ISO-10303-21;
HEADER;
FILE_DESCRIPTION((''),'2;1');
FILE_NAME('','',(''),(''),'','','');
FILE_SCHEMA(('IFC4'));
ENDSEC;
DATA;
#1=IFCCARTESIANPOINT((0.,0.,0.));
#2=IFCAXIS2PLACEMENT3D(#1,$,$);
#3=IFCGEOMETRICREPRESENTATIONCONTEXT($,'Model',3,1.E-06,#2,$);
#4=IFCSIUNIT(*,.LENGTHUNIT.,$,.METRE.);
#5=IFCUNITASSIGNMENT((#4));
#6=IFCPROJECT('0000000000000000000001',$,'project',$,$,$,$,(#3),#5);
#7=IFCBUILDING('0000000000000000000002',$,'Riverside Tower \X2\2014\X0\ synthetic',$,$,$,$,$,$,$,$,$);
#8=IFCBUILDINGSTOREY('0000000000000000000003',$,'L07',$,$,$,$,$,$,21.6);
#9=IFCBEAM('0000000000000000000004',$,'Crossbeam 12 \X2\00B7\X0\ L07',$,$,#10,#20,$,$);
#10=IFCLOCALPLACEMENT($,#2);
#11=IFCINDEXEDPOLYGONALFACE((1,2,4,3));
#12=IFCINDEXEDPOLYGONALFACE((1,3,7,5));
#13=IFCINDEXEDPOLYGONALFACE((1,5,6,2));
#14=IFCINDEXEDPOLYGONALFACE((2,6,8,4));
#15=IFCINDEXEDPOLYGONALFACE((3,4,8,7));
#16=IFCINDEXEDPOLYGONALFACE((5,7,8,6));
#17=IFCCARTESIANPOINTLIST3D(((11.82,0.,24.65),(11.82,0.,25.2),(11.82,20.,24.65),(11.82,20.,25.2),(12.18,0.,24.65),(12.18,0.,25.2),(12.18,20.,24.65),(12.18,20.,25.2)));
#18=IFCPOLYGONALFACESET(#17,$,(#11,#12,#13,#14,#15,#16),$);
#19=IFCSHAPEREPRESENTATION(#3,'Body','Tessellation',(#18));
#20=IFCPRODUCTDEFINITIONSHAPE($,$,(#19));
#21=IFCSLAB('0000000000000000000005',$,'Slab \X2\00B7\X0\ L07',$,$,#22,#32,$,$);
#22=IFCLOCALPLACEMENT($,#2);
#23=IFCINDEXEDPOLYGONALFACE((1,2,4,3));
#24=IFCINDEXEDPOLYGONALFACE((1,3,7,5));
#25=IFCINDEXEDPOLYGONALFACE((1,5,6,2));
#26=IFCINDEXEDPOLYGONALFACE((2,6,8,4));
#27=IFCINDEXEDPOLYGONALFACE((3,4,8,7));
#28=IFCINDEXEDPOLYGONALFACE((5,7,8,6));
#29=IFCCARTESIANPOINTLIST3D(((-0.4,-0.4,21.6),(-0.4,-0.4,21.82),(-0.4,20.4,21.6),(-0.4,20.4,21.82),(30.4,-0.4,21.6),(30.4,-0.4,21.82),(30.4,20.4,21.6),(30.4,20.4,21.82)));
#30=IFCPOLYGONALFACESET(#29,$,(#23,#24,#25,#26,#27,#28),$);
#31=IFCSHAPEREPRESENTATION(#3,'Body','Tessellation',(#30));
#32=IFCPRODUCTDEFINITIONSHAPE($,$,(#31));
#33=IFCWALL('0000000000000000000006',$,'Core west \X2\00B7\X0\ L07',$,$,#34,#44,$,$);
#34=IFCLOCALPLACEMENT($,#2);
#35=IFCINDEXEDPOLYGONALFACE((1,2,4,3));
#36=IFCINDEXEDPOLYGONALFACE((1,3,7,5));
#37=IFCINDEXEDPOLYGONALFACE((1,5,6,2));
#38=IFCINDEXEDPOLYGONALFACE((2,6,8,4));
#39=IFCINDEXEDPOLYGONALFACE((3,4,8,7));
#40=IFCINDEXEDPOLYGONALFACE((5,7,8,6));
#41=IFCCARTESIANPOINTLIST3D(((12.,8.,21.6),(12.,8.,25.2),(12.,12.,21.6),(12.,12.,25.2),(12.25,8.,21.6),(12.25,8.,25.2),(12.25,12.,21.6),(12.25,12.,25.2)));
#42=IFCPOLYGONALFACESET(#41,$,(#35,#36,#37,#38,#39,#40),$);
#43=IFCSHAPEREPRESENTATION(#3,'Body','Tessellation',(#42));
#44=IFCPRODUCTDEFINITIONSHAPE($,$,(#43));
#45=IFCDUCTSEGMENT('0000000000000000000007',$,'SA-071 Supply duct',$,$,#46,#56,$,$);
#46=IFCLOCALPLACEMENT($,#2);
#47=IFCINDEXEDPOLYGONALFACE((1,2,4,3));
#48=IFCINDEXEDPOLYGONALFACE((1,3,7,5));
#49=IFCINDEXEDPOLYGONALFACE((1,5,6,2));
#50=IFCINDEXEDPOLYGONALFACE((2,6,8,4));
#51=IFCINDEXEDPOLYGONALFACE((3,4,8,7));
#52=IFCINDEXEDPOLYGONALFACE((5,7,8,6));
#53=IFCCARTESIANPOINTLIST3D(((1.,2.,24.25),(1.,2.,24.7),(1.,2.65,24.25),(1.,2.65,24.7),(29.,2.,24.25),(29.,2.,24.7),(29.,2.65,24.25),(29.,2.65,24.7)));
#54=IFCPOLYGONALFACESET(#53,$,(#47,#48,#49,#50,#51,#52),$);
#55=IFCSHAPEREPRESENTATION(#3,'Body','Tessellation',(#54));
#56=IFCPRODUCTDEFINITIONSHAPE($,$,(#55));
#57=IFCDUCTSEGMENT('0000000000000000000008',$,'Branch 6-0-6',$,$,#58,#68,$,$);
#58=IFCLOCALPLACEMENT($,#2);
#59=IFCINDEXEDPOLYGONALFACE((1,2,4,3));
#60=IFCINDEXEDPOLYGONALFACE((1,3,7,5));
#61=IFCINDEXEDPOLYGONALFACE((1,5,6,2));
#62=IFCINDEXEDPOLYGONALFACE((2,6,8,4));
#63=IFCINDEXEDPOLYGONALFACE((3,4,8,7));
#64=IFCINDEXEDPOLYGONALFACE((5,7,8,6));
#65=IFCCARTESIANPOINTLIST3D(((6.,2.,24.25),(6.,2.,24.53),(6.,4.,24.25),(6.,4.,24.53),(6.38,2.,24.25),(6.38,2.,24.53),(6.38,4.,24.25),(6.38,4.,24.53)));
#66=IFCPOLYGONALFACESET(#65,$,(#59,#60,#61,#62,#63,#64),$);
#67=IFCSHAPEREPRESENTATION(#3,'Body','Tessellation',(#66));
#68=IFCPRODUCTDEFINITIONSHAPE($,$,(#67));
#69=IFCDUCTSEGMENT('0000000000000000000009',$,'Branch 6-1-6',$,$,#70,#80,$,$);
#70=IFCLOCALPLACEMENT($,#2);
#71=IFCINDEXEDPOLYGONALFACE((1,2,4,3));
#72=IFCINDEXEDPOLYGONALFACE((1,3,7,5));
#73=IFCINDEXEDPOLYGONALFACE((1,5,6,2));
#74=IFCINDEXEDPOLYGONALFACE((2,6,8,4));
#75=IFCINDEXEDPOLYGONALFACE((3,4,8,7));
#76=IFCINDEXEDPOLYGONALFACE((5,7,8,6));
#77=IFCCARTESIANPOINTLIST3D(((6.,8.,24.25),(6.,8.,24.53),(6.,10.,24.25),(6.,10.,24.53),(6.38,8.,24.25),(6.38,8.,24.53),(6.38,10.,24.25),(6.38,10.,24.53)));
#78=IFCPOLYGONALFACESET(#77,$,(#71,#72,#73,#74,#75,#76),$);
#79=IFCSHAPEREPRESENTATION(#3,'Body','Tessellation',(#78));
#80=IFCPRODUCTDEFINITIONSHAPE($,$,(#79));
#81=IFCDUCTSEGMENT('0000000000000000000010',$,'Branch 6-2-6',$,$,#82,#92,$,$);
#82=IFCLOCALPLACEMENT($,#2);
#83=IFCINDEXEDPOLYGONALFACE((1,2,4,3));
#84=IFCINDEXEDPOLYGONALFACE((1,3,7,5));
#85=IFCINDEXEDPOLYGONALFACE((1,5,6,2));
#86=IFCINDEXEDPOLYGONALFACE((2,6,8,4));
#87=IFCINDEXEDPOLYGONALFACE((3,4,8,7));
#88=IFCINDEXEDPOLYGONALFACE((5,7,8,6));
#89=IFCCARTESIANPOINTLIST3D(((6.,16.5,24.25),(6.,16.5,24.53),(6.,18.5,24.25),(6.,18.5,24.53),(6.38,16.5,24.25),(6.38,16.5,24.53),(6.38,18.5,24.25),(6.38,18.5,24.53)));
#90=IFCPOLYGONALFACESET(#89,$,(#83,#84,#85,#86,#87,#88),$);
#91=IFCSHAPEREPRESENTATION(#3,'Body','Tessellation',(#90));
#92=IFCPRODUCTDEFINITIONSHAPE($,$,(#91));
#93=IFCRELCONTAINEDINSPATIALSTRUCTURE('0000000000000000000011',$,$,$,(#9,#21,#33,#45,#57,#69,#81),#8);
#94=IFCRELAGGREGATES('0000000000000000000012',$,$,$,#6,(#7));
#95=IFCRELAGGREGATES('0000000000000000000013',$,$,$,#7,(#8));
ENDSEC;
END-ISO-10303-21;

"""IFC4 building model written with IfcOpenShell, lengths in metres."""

from ifc_helpers import new_model, si_unit, frame, origin, place, context, project, spatial, rectangle, extrude, element, save


model = new_model("IFC4")

# Units and contexts
model_context = context("Model", 3, precision=1e-06, world=origin())
ifc_project = project(units=[si_unit("LENGTHUNIT", "METRE")], contexts=[model_context])

# Building, storey
building = spatial("IfcBuilding", under=ifc_project, Name="Riverside Tower — synthetic")
storey = spatial("IfcBuildingStorey", under=building, Name="L07", Elevation=21.6)

# Beam
for number, where, name in (
    (1, (12.0, 10.0, 24.65), "Crossbeam 12 · L07"),
):
    element("IfcBeam", number, at=place(None, frame(where)), inside=storey, Name=name, context=model_context, shape_type="SweptSolid", body=[
        extrude(rectangle(XDim=0.36, YDim=20.0), origin(), (0.0, 0.0, 1.0), 0.55),
    ])

# Slab
slab_placement = place(None, frame((15.0, 10.0, 21.6)))
element("IfcSlab", 2, at=slab_placement, inside=storey, Name="Slab · L07", context=model_context, shape_type="SweptSolid", body=[
    extrude(rectangle(XDim=30.8, YDim=20.8), origin(), (0.0, 0.0, 1.0), 0.22),
])

# Wall
wall_placement = place(None, frame((12.125, 10.0, 21.6)))
element("IfcWall", 3, at=wall_placement, inside=storey, Name="Core west · L07", context=model_context, shape_type="SweptSolid", body=[
    extrude(rectangle(XDim=0.25, YDim=4.0), origin(), (0.0, 0.0, 1.0), 3.6),
])

# Duct segments
duct_segment_placement = place(None, frame((15.0, 2.325, 24.25)))
element("IfcDuctSegment", 4, at=duct_segment_placement, inside=storey, Name="SA-071 Supply duct", context=model_context, shape_type="SweptSolid", body=[
    extrude(rectangle(XDim=28.0, YDim=0.65), origin(), (0.0, 0.0, 1.0), 0.45),
])
for number, where, name in (
    (5, (6.19, 3.0, 24.25), "Branch 6-0-6"),
    (6, (6.19, 9.0, 24.25), "Branch 6-1-6"),
    (7, (6.19, 17.5, 24.25), "Branch 6-2-6"),
):
    element("IfcDuctSegment", number, at=place(None, frame(where)), inside=storey, Name=name, context=model_context, shape_type="SweptSolid", body=[
        extrude(rectangle(XDim=0.38, YDim=2.0), origin(), (0.0, 0.0, 1.0), 0.28),
    ])

save(model, "model.ifc")
